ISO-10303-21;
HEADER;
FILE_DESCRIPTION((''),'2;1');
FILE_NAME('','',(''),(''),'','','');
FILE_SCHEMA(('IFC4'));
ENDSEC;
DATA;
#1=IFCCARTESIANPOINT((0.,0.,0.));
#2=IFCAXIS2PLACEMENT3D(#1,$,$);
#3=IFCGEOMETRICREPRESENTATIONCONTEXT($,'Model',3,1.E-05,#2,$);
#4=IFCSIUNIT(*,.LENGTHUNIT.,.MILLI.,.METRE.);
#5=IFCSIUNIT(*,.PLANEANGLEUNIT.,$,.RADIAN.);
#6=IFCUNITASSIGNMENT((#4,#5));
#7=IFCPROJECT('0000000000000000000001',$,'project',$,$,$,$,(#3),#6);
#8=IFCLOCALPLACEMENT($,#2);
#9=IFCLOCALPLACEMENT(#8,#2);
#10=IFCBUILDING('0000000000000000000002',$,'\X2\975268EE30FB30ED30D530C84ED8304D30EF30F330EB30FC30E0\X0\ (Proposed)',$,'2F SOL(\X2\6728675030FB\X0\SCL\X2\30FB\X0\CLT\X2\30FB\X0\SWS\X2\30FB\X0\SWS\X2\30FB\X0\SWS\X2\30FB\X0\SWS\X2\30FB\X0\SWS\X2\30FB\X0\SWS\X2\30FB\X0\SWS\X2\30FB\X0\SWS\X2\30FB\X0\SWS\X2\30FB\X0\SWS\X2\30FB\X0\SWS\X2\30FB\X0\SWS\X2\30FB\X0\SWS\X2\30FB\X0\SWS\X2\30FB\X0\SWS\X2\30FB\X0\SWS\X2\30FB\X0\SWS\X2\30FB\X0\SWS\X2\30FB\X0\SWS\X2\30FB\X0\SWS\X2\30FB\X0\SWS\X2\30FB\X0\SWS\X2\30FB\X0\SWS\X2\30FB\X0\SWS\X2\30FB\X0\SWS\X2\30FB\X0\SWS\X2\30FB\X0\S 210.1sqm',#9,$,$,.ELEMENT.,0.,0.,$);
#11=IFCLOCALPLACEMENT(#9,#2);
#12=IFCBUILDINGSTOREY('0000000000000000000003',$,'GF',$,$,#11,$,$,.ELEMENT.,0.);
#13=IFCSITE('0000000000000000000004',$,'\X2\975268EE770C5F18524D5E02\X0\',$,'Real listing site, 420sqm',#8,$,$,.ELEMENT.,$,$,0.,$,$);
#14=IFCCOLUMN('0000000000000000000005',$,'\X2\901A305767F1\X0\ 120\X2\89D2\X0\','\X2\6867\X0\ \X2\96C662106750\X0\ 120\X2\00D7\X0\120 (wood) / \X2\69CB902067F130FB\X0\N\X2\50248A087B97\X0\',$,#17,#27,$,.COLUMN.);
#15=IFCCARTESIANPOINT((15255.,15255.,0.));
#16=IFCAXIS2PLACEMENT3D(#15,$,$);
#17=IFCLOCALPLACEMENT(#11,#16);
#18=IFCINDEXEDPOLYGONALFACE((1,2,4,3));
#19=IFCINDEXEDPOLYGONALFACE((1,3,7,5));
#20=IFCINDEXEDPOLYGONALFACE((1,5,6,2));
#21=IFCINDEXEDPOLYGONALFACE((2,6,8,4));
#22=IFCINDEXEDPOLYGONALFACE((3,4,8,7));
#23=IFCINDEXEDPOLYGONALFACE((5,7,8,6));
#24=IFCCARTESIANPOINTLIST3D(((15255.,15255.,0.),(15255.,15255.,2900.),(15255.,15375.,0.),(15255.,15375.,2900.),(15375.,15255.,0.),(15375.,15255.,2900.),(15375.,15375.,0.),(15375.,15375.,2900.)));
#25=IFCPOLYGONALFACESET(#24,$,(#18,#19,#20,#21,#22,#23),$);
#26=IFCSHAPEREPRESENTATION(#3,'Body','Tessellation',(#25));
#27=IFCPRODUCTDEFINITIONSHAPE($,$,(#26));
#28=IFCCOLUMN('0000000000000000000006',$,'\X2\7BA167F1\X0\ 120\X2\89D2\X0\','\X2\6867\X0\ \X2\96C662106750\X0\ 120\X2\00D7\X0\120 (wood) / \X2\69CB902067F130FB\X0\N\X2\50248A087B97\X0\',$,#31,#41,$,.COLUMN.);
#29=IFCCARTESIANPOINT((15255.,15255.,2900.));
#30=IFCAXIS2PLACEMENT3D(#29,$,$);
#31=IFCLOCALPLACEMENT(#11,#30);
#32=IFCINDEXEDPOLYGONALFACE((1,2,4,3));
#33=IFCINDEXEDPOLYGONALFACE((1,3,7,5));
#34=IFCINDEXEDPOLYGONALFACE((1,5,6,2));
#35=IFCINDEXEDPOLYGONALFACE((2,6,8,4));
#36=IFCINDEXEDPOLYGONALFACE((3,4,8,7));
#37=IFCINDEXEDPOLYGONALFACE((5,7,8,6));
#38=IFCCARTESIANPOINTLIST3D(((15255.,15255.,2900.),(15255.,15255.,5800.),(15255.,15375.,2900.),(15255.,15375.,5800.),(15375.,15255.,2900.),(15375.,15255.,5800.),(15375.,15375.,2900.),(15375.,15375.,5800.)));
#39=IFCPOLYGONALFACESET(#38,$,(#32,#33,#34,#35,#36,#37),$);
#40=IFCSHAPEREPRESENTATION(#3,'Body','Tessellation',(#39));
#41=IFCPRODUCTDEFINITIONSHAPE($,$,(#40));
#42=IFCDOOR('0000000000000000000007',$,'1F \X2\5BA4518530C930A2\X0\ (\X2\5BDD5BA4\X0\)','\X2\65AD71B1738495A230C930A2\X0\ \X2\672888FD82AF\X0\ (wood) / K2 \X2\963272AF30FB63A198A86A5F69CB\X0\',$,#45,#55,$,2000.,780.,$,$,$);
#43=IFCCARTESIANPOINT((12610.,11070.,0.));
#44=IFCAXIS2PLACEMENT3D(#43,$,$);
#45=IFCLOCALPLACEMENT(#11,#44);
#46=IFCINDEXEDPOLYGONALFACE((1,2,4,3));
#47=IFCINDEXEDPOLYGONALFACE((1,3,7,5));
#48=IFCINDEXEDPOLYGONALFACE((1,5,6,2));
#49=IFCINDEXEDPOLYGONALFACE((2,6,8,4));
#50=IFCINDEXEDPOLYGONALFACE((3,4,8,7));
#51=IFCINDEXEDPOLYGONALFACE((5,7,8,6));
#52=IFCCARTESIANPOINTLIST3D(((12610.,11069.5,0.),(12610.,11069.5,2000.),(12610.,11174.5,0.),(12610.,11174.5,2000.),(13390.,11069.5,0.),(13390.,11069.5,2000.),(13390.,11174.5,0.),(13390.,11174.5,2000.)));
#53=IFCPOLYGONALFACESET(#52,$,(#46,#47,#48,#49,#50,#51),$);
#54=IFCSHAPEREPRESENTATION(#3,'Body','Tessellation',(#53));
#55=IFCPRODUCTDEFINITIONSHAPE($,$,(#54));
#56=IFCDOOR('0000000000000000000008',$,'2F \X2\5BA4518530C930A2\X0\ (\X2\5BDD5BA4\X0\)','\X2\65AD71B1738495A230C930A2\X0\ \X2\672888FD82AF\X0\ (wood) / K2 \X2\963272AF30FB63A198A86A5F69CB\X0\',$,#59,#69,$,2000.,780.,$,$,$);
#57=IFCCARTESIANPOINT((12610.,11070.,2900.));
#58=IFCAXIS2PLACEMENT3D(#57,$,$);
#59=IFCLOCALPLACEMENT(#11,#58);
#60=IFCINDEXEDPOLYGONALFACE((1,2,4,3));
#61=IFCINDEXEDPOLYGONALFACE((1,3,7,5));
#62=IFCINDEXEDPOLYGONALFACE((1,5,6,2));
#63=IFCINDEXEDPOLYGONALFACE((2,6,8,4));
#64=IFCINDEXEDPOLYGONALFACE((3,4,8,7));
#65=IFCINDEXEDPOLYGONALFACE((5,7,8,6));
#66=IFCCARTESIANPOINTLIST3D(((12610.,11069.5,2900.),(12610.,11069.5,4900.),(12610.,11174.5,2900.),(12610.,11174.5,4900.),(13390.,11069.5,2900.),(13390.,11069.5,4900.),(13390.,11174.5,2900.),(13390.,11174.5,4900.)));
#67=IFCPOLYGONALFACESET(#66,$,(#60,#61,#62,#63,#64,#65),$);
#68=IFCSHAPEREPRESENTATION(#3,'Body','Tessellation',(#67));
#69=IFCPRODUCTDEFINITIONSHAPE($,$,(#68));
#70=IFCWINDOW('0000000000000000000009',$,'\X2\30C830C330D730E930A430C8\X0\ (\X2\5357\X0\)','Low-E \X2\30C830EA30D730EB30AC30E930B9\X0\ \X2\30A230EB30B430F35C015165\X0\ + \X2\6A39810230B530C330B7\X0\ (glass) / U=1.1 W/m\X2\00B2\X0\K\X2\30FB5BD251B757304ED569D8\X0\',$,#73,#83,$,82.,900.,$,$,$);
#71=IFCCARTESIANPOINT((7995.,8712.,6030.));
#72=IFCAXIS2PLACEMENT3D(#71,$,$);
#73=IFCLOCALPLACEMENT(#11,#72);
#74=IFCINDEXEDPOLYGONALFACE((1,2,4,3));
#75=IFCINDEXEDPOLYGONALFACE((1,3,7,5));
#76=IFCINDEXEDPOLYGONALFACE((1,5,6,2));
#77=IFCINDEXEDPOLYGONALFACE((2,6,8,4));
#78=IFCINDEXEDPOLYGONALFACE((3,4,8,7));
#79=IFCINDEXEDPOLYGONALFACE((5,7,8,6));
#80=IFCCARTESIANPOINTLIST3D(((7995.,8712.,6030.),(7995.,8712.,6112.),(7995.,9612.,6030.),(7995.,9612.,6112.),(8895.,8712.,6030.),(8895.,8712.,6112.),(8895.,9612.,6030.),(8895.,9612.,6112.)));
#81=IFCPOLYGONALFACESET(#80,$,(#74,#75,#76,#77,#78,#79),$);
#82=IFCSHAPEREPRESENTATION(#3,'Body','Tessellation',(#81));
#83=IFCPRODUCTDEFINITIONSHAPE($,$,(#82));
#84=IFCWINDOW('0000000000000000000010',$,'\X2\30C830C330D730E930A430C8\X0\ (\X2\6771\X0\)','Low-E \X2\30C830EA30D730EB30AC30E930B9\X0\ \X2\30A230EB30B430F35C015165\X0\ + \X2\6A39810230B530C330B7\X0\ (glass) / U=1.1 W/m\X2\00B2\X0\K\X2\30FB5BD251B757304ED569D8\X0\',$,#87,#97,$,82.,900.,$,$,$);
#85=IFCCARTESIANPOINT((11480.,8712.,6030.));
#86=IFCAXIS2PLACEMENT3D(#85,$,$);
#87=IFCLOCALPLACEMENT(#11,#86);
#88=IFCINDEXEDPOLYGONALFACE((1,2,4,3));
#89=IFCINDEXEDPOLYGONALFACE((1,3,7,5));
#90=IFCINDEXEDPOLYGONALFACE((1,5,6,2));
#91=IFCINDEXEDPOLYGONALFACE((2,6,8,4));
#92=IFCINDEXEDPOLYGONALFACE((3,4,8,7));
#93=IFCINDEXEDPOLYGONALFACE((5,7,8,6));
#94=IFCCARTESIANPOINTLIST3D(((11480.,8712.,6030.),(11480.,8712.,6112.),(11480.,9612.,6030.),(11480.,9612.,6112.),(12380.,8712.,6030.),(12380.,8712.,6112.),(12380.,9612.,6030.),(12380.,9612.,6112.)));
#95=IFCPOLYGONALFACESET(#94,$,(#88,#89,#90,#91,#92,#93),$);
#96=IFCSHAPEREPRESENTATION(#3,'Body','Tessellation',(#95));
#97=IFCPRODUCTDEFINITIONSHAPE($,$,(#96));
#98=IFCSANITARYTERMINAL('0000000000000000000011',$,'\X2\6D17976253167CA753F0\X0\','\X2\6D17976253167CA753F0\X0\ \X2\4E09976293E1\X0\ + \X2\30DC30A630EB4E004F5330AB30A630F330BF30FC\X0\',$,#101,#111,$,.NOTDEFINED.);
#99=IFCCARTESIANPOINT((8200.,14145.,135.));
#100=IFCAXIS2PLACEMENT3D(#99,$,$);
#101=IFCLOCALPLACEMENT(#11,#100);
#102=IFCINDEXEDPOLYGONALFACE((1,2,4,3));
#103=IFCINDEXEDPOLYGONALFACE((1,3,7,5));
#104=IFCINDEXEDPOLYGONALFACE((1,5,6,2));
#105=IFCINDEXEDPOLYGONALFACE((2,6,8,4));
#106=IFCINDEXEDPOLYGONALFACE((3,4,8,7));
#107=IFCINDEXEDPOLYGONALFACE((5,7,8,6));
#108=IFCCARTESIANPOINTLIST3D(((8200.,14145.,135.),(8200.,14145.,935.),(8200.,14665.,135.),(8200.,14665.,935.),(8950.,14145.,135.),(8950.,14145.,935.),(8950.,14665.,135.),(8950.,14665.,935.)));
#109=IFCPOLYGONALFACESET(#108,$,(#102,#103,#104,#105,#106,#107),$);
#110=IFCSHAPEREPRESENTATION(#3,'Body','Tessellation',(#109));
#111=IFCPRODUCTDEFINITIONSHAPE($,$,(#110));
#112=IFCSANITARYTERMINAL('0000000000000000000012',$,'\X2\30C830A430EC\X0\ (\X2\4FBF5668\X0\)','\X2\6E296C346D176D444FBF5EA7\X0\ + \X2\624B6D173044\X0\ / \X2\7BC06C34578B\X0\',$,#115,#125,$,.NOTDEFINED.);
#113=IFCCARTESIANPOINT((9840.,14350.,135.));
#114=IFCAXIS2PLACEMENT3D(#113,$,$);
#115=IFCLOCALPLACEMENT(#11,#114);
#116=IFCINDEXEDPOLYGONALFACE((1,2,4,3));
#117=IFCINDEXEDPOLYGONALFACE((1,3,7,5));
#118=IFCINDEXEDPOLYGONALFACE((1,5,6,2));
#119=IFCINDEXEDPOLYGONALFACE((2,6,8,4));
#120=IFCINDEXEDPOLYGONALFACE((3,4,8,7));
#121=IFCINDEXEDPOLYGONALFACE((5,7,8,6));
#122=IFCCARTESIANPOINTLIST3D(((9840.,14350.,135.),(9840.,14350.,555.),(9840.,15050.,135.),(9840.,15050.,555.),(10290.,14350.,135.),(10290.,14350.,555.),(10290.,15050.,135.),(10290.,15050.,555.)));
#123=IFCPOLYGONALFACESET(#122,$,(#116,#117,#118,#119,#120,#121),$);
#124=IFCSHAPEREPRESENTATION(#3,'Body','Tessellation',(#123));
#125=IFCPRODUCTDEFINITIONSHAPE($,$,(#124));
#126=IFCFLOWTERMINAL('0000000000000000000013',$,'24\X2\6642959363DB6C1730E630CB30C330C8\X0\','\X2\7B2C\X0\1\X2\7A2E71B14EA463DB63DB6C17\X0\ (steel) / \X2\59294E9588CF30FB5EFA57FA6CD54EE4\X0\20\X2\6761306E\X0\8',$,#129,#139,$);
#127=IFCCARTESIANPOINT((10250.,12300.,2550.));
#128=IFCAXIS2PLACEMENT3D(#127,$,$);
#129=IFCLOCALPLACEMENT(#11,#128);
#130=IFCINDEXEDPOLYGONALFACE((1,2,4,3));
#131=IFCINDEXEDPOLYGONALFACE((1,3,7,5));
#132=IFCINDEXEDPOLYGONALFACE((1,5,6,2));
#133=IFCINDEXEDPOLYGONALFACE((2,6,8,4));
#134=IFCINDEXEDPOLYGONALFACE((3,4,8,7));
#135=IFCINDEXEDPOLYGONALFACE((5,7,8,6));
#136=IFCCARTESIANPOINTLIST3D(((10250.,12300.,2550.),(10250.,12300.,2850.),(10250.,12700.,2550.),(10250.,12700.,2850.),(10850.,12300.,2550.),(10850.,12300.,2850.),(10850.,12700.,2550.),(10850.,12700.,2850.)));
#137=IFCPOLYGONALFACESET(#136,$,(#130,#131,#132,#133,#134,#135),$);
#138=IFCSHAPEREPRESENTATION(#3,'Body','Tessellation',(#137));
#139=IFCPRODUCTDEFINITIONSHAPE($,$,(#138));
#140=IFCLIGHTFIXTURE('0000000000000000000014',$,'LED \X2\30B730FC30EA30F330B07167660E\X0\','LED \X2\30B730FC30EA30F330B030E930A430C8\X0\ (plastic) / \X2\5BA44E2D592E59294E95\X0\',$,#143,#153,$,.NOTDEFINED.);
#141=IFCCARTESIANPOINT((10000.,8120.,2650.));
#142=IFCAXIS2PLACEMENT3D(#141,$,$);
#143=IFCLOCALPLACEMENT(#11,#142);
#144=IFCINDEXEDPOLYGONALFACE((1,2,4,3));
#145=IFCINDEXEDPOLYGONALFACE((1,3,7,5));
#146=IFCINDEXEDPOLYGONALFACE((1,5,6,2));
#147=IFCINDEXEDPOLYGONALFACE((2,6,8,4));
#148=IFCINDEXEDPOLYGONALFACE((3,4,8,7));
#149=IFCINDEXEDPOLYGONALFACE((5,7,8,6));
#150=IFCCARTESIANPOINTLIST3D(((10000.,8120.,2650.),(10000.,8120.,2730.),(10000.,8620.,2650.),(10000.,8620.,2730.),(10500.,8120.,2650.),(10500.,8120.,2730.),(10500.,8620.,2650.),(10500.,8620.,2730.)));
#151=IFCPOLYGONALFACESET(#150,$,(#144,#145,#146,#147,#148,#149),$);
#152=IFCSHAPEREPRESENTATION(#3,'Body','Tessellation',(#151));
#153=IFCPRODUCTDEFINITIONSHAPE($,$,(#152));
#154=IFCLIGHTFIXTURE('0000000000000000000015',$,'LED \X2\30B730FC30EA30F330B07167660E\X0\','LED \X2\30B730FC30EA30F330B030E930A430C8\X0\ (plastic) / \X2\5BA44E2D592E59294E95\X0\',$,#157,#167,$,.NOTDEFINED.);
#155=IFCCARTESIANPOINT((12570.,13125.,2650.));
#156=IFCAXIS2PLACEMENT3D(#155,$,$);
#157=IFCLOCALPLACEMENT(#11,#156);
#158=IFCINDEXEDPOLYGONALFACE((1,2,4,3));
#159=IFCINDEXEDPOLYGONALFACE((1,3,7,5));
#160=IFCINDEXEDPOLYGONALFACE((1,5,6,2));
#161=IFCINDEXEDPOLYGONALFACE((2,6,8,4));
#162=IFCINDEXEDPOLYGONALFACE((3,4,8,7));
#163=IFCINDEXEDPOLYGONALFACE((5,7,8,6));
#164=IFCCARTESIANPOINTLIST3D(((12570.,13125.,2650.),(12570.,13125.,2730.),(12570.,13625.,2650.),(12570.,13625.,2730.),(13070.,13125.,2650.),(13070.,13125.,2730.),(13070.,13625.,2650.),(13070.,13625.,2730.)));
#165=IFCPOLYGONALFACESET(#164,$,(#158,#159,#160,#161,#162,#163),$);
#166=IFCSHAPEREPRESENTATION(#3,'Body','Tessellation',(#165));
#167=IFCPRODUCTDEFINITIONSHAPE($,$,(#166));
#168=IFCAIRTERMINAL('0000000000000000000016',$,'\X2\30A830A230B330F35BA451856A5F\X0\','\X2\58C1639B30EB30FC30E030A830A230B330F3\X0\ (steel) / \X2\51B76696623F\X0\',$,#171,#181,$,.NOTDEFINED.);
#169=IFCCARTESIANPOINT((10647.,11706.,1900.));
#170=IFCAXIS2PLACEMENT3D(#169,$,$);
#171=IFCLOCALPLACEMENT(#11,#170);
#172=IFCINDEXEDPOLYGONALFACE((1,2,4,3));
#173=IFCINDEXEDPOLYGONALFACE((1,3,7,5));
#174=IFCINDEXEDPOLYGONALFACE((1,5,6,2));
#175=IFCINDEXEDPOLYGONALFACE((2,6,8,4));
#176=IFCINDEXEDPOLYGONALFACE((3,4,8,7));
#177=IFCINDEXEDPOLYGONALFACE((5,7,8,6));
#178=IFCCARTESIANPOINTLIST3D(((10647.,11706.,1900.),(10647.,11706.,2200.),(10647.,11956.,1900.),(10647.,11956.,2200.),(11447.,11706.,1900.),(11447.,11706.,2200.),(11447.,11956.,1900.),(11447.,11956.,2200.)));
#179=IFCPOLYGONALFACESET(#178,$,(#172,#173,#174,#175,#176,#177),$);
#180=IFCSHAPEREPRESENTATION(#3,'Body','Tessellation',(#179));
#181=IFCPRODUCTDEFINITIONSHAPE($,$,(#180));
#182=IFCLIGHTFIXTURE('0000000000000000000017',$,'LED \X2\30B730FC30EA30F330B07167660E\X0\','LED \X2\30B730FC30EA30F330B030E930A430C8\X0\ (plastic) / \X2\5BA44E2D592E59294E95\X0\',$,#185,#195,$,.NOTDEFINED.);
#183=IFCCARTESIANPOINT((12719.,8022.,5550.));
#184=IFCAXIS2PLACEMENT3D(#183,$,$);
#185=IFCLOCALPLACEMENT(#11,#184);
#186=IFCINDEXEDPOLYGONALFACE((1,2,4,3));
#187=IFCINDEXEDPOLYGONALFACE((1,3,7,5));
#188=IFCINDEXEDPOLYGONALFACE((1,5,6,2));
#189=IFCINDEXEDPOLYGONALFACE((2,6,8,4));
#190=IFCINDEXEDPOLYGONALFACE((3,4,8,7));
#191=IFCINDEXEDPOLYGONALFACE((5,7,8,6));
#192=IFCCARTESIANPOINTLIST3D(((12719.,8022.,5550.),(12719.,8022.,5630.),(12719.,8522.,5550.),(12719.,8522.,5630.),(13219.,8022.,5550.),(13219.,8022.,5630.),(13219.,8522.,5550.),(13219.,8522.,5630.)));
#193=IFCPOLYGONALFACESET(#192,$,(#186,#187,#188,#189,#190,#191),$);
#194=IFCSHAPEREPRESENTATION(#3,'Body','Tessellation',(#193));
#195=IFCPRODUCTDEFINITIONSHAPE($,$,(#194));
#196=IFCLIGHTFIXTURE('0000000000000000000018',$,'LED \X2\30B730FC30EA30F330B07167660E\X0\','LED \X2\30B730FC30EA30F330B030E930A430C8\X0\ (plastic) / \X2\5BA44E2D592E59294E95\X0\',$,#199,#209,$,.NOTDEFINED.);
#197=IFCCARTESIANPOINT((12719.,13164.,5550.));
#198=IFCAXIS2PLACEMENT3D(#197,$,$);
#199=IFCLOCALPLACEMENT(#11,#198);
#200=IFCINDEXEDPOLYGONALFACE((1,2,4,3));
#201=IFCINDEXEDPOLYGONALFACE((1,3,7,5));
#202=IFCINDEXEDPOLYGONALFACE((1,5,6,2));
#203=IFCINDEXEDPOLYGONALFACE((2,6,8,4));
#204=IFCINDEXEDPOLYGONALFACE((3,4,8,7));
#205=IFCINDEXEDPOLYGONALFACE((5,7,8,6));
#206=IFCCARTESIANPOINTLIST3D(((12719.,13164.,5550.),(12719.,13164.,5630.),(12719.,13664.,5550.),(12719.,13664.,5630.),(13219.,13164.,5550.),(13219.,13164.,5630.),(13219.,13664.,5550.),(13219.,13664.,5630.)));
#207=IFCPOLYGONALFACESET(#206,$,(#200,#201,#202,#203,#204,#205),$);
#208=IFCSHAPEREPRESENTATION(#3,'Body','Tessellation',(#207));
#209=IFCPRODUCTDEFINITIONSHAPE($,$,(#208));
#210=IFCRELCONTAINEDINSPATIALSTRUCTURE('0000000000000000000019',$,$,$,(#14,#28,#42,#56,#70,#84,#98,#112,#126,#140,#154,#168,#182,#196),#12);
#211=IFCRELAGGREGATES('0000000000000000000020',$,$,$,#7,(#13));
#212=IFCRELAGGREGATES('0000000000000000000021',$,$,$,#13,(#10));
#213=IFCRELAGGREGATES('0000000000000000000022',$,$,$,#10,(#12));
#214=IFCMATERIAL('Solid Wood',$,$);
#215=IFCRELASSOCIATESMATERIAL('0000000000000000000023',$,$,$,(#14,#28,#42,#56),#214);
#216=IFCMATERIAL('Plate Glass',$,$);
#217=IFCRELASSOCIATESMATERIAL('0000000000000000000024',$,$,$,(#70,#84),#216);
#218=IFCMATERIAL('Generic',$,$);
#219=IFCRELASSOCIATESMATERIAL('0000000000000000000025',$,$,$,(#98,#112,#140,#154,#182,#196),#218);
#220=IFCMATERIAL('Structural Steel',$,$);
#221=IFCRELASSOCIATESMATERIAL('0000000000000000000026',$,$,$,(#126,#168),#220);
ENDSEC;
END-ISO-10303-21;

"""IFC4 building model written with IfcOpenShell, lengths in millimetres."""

from ifc_helpers import new_model, si_unit, frame, frame_2d, origin, place, context, project, spatial, rectangle, extrude, material, element, save


model = new_model("IFC4")

# Units and contexts
model_context = context("Model", 3, precision=1e-05, world=origin())
ifc_project = project(units=[si_unit("LENGTHUNIT", "METRE", prefix="MILLI"), si_unit("PLANEANGLEUNIT", "RADIAN")], contexts=[model_context])

# Site, building, storey
site_placement = place(None, origin())
site = spatial("IfcSite", under=ifc_project, at=site_placement, Name="青森県弘前市", ObjectType="Real listing site, 420sqm", CompositionType="ELEMENT", RefElevation=0.0)
building_placement = place(site_placement, origin())
building = spatial("IfcBuilding", under=site, at=building_placement, Name="青森・ロフト付きワンルーム (Proposed)", ObjectType="2F SOL(木材・SCL・CLT・SWS・SWS・SWS・SWS・SWS・SWS・SWS・SWS・SWS・SWS・SWS・SWS・SWS・SWS・SWS・SWS・SWS・SWS・SWS・SWS・SWS・SWS・SWS・SWS・SWS・SWS・S 210.1sqm", CompositionType="ELEMENT", ElevationOfRefHeight=0.0, ElevationOfTerrain=0.0)
storey_placement = place(building_placement, origin())
storey = spatial("IfcBuildingStorey", under=building, at=storey_placement, Name="GF", CompositionType="ELEMENT", Elevation=0.0)

# Columns
ifc_material_1 = material(Name="Solid Wood")
column_1_placement = place(storey_placement, frame((15255.0, 15255.0, 0.0)))
element("IfcColumn", 1, at=column_1_placement, inside=storey, material=ifc_material_1, Name="通し柱 120角", Description="桧 集成材 120×120 (wood) / 構造柱・N値計算", PredefinedType="COLUMN", context=model_context, shape_type="SweptSolid", body=[
    extrude(rectangle(XDim=120.0, YDim=120.0, at=frame_2d((60.0, 60.0))), frame((15255.0, 15255.0, 0.0)), (0.0, 0.0, 1.0), 2900.0),
])
column_2_placement = place(storey_placement, frame((15255.0, 15255.0, 2900.0)))
element("IfcColumn", 2, at=column_2_placement, inside=storey, material=ifc_material_1, Name="管柱 120角", Description="桧 集成材 120×120 (wood) / 構造柱・N値計算", PredefinedType="COLUMN", context=model_context, shape_type="SweptSolid", body=[
    extrude(rectangle(XDim=120.0, YDim=120.0, at=frame_2d((60.0, 60.0))), frame((15255.0, 15255.0, 2900.0)), (0.0, 0.0, 1.0), 2900.0),
])

# Door
door_1_placement = place(storey_placement, frame((12610.0, 11070.0, 0.0)))
element("IfcDoor", 3, at=door_1_placement, inside=storey, material=ifc_material_1, Name="1F 室内ドア (寝室)", Description="断熱玄関ドア 木製芯 (wood) / K2 防犯・採風機構", OverallHeight=2000.0, OverallWidth=780.0, context=model_context, shape_type="SweptSolid", body=[
    extrude(rectangle(XDim=780.0, YDim=105.0, at=frame_2d((390.0, 52.0))), frame((12610.0, 11070.0, 0.0)), (0.0, 0.0, 1.0), 2000.0),
])

# Door
door_2_placement = place(storey_placement, frame((12610.0, 11070.0, 2900.0)))
element("IfcDoor", 4, at=door_2_placement, inside=storey, material=ifc_material_1, Name="2F 室内ドア (寝室)", Description="断熱玄関ドア 木製芯 (wood) / K2 防犯・採風機構", OverallHeight=2000.0, OverallWidth=780.0, context=model_context, shape_type="SweptSolid", body=[
    extrude(rectangle(XDim=780.0, YDim=105.0, at=frame_2d((390.0, 52.0))), frame((12610.0, 11070.0, 2900.0)), (0.0, 0.0, 1.0), 2000.0),
])

# Windows
ifc_material_2 = material(Name="Plate Glass")
window_1_placement = place(storey_placement, frame((7995.0, 8712.0, 6030.0)))
element("IfcWindow", 5, at=window_1_placement, inside=storey, material=ifc_material_2, Name="トップライト (南)", Description="Low-E トリプルガラス アルゴン封入 + 樹脂サッシ (glass) / U=1.1 W/m²K・寒冷地仕様", OverallHeight=82.0, OverallWidth=900.0, context=model_context, shape_type="SweptSolid", body=[
    extrude(rectangle(XDim=900.0, YDim=900.0, at=frame_2d((450.0, 450.0))), frame((7995.0, 8712.0, 6030.0)), (0.0, 0.0, 1.0), 82.0),
])
window_2_placement = place(storey_placement, frame((11480.0, 8712.0, 6030.0)))
element("IfcWindow", 6, at=window_2_placement, inside=storey, material=ifc_material_2, Name="トップライト (東)", Description="Low-E トリプルガラス アルゴン封入 + 樹脂サッシ (glass) / U=1.1 W/m²K・寒冷地仕様", OverallHeight=82.0, OverallWidth=900.0, context=model_context, shape_type="SweptSolid", body=[
    extrude(rectangle(XDim=900.0, YDim=900.0, at=frame_2d((450.0, 450.0))), frame((11480.0, 8712.0, 6030.0)), (0.0, 0.0, 1.0), 82.0),
])

# Sanitary terminals
ifc_material_3 = material(Name="Generic")
sanitary_terminal_1_placement = place(storey_placement, frame((8200.0, 14145.0, 135.0)))
element("IfcSanitaryTerminal", 7, at=sanitary_terminal_1_placement, inside=storey, material=ifc_material_3, Name="洗面化粧台", Description="洗面化粧台 三面鏡 + ボウル一体カウンター", PredefinedType="NOTDEFINED", context=model_context, shape_type="SweptSolid", body=[
    extrude(rectangle(XDim=750.0, YDim=520.0, at=frame_2d((375.0, 260.0))), frame((8200.0, 14145.0, 135.0)), (0.0, 0.0, 1.0), 800.0),
])
sanitary_terminal_2_placement = place(storey_placement, frame((9840.0, 14350.0, 135.0)))
element("IfcSanitaryTerminal", 8, at=sanitary_terminal_2_placement, inside=storey, material=ifc_material_3, Name="トイレ (便器)", Description="温水洗浄便座 + 手洗い / 節水型", PredefinedType="NOTDEFINED", context=model_context, shape_type="SweptSolid", body=[
    extrude(rectangle(XDim=450.0, YDim=700.0, at=frame_2d((225.0, 350.0))), frame((9840.0, 14350.0, 135.0)), (0.0, 0.0, 1.0), 420.0),
])

# Flow terminal
ifc_material_4 = material(Name="Structural Steel")
flow_terminal_placement = place(storey_placement, frame((10250.0, 12300.0, 2550.0)))
element("IfcFlowTerminal", 9, at=flow_terminal_placement, inside=storey, material=ifc_material_4, Name="24時間換気ユニット", Description="第1種熱交換換気 (steel) / 天井裏・建基法令20条の8", context=model_context, shape_type="SweptSolid", body=[
    extrude(rectangle(XDim=600.0, YDim=400.0, at=frame_2d((300.0, 200.0))), frame((10250.0, 12300.0, 2550.0)), (0.0, 0.0, 1.0), 300.0),
])

# Light fixtures
light_fixture_1_placement = place(storey_placement, frame((10000.0, 8120.0, 2650.0)))
element("IfcLightFixture", 10, at=light_fixture_1_placement, inside=storey, material=ifc_material_3, Name="LED シーリング照明", Description="LED シーリングライト (plastic) / 室中央天井", PredefinedType="NOTDEFINED", context=model_context, shape_type="SweptSolid", body=[
    extrude(rectangle(XDim=500.0, YDim=500.0, at=frame_2d((250.0, 250.0))), frame((10000.0, 8120.0, 2650.0)), (0.0, 0.0, 1.0), 80.0),
])
light_fixture_2_placement = place(storey_placement, frame((12570.0, 13125.0, 2650.0)))
element("IfcLightFixture", 11, at=light_fixture_2_placement, inside=storey, material=ifc_material_3, Name="LED シーリング照明", Description="LED シーリングライト (plastic) / 室中央天井", PredefinedType="NOTDEFINED", context=model_context, shape_type="SweptSolid", body=[
    extrude(rectangle(XDim=500.0, YDim=500.0, at=frame_2d((250.0, 250.0))), frame((12570.0, 13125.0, 2650.0)), (0.0, 0.0, 1.0), 80.0),
])

# Air terminal
air_terminal_placement = place(storey_placement, frame((10647.0, 11706.0, 1900.0)))
element("IfcAirTerminal", 12, at=air_terminal_placement, inside=storey, material=ifc_material_4, Name="エアコン室内機", Description="壁掛ルームエアコン (steel) / 冷暖房", PredefinedType="NOTDEFINED", context=model_context, shape_type="SweptSolid", body=[
    extrude(rectangle(XDim=800.0, YDim=250.0, at=frame_2d((400.0, 125.0))), frame((10647.0, 11706.0, 1900.0)), (0.0, 0.0, 1.0), 300.0),
])

# Light fixtures
light_fixture_3_placement = place(storey_placement, frame((12719.0, 8022.0, 5550.0)))
element("IfcLightFixture", 13, at=light_fixture_3_placement, inside=storey, material=ifc_material_3, Name="LED シーリング照明", Description="LED シーリングライト (plastic) / 室中央天井", PredefinedType="NOTDEFINED", context=model_context, shape_type="SweptSolid", body=[
    extrude(rectangle(XDim=500.0, YDim=500.0, at=frame_2d((250.0, 250.0))), frame((12719.0, 8022.0, 5550.0)), (0.0, 0.0, 1.0), 80.0),
])
light_fixture_4_placement = place(storey_placement, frame((12719.0, 13164.0, 5550.0)))
element("IfcLightFixture", 14, at=light_fixture_4_placement, inside=storey, material=ifc_material_3, Name="LED シーリング照明", Description="LED シーリングライト (plastic) / 室中央天井", PredefinedType="NOTDEFINED", context=model_context, shape_type="SweptSolid", body=[
    extrude(rectangle(XDim=500.0, YDim=500.0, at=frame_2d((250.0, 250.0))), frame((12719.0, 13164.0, 5550.0)), (0.0, 0.0, 1.0), 80.0),
])

save(model, "model.ifc")
